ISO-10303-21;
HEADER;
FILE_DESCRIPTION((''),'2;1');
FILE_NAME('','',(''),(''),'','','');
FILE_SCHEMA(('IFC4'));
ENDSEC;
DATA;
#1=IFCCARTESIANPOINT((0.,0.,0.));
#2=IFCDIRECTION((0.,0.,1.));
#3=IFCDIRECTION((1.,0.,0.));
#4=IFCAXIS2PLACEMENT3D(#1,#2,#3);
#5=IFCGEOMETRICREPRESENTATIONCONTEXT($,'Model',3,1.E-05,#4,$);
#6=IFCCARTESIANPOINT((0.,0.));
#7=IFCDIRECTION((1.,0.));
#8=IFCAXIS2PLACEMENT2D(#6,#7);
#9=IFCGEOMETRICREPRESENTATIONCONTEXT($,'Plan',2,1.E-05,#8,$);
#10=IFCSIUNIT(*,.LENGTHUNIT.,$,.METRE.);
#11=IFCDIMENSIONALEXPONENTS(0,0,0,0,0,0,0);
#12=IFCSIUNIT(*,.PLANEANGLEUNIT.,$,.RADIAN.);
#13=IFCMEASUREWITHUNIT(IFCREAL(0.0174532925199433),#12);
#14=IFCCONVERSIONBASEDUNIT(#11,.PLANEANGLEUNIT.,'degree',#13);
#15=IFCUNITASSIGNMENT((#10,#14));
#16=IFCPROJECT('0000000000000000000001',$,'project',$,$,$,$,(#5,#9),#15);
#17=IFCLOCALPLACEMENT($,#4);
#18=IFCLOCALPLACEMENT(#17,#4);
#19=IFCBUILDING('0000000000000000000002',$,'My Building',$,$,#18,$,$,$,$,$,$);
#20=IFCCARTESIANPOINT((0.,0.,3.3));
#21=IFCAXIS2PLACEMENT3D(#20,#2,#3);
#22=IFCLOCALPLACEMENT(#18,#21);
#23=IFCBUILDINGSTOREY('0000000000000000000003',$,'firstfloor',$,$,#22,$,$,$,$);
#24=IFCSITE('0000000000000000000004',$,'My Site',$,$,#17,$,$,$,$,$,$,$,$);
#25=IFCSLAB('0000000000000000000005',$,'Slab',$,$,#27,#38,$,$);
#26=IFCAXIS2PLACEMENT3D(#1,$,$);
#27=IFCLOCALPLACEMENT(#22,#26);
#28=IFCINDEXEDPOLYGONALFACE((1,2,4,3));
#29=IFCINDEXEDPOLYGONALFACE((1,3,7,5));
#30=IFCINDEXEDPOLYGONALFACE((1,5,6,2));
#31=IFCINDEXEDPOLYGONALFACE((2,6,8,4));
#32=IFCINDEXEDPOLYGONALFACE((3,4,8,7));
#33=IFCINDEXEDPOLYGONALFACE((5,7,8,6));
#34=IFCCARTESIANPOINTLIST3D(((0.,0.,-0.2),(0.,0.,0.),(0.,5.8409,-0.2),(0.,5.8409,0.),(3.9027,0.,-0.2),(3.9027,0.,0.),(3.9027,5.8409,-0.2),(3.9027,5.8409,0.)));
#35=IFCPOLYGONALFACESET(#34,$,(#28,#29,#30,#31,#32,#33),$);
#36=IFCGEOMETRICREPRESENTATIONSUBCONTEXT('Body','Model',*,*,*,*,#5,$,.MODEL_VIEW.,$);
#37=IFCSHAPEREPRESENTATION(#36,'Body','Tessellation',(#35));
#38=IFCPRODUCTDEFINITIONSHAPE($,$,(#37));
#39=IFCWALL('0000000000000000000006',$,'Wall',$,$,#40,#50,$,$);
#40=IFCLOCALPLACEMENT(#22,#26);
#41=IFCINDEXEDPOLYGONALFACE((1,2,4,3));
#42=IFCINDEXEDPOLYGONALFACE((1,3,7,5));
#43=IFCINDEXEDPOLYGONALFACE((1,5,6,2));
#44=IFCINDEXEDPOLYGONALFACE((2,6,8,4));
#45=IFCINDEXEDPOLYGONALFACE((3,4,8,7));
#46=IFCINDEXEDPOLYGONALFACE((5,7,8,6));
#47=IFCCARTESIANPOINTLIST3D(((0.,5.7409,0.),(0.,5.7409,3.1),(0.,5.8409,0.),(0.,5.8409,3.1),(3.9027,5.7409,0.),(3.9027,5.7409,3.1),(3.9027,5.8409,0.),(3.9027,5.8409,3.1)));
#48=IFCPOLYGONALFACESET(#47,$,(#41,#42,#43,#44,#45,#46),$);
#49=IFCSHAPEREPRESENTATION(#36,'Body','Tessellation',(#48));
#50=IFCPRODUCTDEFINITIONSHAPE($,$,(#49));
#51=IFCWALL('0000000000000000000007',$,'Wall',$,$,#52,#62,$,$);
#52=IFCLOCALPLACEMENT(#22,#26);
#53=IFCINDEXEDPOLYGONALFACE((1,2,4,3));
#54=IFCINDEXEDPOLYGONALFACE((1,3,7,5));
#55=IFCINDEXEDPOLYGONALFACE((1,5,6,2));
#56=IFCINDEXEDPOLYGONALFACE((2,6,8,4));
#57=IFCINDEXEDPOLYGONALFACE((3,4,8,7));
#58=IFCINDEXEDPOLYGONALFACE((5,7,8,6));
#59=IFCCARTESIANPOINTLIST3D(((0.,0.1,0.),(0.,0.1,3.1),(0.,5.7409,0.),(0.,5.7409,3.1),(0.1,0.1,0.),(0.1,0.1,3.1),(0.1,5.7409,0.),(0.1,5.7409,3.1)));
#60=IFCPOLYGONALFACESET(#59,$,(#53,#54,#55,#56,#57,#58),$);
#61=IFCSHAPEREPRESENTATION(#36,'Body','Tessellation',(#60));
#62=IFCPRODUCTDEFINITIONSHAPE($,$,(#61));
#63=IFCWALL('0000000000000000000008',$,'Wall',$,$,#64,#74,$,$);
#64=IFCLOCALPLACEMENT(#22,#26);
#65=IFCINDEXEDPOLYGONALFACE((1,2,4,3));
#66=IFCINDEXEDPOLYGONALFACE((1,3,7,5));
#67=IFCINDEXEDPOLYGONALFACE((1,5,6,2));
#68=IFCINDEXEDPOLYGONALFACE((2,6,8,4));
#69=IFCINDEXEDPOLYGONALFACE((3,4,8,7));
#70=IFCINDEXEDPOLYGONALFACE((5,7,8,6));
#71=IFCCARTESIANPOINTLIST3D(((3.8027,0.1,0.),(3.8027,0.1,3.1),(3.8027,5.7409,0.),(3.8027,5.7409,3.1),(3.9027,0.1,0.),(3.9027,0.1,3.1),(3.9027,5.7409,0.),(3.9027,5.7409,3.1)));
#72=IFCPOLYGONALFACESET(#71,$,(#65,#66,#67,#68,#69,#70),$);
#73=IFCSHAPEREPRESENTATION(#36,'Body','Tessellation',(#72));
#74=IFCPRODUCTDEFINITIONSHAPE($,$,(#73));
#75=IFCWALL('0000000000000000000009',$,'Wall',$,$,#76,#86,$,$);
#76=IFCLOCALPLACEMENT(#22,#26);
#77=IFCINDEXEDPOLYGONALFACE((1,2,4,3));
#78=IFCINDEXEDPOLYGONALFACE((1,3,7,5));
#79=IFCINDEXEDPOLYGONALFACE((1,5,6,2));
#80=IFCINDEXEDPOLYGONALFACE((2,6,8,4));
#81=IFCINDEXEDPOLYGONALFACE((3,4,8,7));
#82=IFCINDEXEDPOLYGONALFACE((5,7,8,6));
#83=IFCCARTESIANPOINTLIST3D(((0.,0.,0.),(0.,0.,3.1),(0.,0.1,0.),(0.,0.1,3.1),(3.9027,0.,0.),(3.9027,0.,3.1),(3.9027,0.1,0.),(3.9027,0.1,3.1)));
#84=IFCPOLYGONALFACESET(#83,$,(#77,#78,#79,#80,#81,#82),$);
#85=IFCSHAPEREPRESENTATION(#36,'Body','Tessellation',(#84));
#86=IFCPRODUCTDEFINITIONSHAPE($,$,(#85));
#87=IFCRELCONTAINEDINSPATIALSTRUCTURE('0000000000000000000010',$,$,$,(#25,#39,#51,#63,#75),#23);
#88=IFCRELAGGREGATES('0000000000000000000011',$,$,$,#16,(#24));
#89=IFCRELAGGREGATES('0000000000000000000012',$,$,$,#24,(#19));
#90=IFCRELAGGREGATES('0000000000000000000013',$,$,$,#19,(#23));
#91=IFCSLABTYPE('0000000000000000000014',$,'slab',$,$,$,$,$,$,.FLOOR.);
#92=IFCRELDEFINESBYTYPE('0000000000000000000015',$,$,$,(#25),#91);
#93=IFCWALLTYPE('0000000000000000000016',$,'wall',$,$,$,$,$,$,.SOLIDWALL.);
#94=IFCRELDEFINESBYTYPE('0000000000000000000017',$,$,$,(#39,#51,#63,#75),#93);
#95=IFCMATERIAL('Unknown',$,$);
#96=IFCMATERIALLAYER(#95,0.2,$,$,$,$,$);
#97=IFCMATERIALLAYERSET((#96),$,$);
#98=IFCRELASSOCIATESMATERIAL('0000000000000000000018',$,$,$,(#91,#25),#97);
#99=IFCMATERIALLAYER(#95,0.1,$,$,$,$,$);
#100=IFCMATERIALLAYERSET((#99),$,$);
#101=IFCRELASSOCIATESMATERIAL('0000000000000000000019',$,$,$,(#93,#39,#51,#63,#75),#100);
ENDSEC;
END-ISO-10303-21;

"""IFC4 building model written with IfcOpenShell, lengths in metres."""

from ifc_helpers import new_model, entity, si_unit, converted_unit, frame, origin_with_axes, origin_2d_with_axis, place, context, subcontext, project, spatial, line, indexed_curve, outline, extrude, clip, halfspace, material, layer, layer_set, layer_usage, type_object, element, save


model = new_model("IFC4")

# Units and contexts
model_context = context("Model", 3, precision=1e-05, world=origin_with_axes())
plan_context = context("Plan", 2, precision=1e-05, world=origin_2d_with_axis())
body_context = subcontext(model_context, "Body", "Model", "MODEL_VIEW")
ifc_project = project(units=[si_unit("LENGTHUNIT", "METRE"), converted_unit("PLANEANGLEUNIT", "degree", entity("IfcReal", 0.0174532925199433), si_unit("PLANEANGLEUNIT", "RADIAN"), dimensions=[0, 0, 0, 0, 0, 0, 0])], contexts=[model_context, plan_context])

# Site, building, storey
site_placement = place(None, origin_with_axes())
site = spatial("IfcSite", under=ifc_project, at=site_placement, Name="My Site")
building_placement = place(site_placement, origin_with_axes())
building = spatial("IfcBuilding", under=site, at=building_placement, Name="My Building")
storey_placement = place(building_placement, frame((0.0, 0.0, 3.3), z_axis=(0.0, 0.0, 1.0), x_axis=(1.0, 0.0, 0.0)))
storey = spatial("IfcBuildingStorey", under=building, at=storey_placement, Name="firstfloor")

# Slab
ifc_material = material(Name="Unknown")
ifc_layer_1 = layer(ifc_material, 0.2)
ifc_layer_set_1 = layer_set([ifc_layer_1])
ifc_layer_usage_1 = layer_usage(ifc_layer_set_1, "AXIS3", "POSITIVE", 0.0)
slab_type = type_object("IfcSlabType", Name="slab", PredefinedType="FLOOR", material=ifc_layer_set_1)
slab_placement = place(storey_placement, frame((0.0, 0.0, -0.2), z_axis=(0.0, 0.0, 1.0), x_axis=(1.0, 0.0, 0.0)))
element("IfcSlab", 1, at=slab_placement, inside=storey, type_object=slab_type, material=ifc_layer_usage_1, Name="Slab", context=body_context, shape_type="SweptSolid", body=[
    extrude(outline(indexed_curve([(0.0, 0.0), (3.9027, 0.0), (3.9027, 5.8409), (0.0, 5.8409)], segments=[line(3, 2), line(2, 1), line(1, 4), line(4, 3)], self_intersect=False)), None, (0.0, 0.0, 1.0), 0.2),
])

# Walls
ifc_layer_2 = layer(ifc_material, 0.1)
ifc_layer_set_2 = layer_set([ifc_layer_2])
ifc_layer_usage_2 = layer_usage(ifc_layer_set_2, "AXIS2", "POSITIVE", 0.0)
wall_type = type_object("IfcWallType", Name="wall", PredefinedType="SOLIDWALL", material=ifc_layer_set_2)
wall_1_placement = place(storey_placement, frame((0.0, 5.7409, 0.0), z_axis=(0.0, 0.0, 1.0), x_axis=(1.0, 0.0, 0.0)))
element("IfcWall", 2, at=wall_1_placement, inside=storey, type_object=wall_type, material=ifc_layer_usage_2, Name="Wall", context=body_context, shape_type="Clipping", body=[
    clip(extrude(outline(indexed_curve([(0.0, 0.0), (0.0, 0.1), (3.9027, 0.1), (3.9027, 0.0), (0.0, 0.0)], self_intersect=False)), origin_with_axes(), (0.0, 0.0, 1.0), 6.4), halfspace(frame((0.0, 0.0, 3.1), z_axis=(0.0, 0.0, 1.0), x_axis=(-1.0, 0.0, 0.0)), False)),
])
ifc_layer_usage_3 = layer_usage(ifc_layer_set_2, "AXIS2", "POSITIVE", 0.0)
wall_2_placement = place(storey_placement, frame((0.0, 5.7409, 0.0), z_axis=(0.0, 0.0, 1.0), x_axis=(0.0, -1.0, 0.0)))
element("IfcWall", 3, at=wall_2_placement, inside=storey, type_object=wall_type, material=ifc_layer_usage_3, Name="Wall", context=body_context, shape_type="Clipping", body=[
    clip(extrude(outline(indexed_curve([(0.0, 0.0), (0.0, 0.1), (5.6409, 0.1), (5.6409, 0.0), (0.0, 0.0)], self_intersect=False)), origin_with_axes(), (0.0, 0.0, 1.0), 6.4), halfspace(frame((0.0, 0.0, 3.1), z_axis=(0.0, 0.0, 1.0), x_axis=(-1.0, 0.0, 0.0)), False)),
])
ifc_layer_usage_4 = layer_usage(ifc_layer_set_2, "AXIS2", "POSITIVE", 0.0)
wall_3_placement = place(storey_placement, frame((3.8027, 5.7409, 0.0), z_axis=(0.0, 0.0, 1.0), x_axis=(0.0, -1.0, 0.0)))
element("IfcWall", 4, at=wall_3_placement, inside=storey, type_object=wall_type, material=ifc_layer_usage_4, Name="Wall", context=body_context, shape_type="Clipping", body=[
    clip(extrude(outline(indexed_curve([(0.0, 0.0), (0.0, 0.1), (5.6409, 0.1), (5.6409, 0.0), (0.0, 0.0)], self_intersect=False)), origin_with_axes(), (0.0, 0.0, 1.0), 6.4), halfspace(frame((0.0, 0.0, 3.1), z_axis=(0.0, 0.0, 1.0), x_axis=(-1.0, 0.0, 0.0)), False)),
])
ifc_layer_usage_5 = layer_usage(ifc_layer_set_2, "AXIS2", "POSITIVE", 0.0)
wall_4_placement = place(storey_placement, origin_with_axes())
element("IfcWall", 5, at=wall_4_placement, inside=storey, type_object=wall_type, material=ifc_layer_usage_5, Name="Wall", context=body_context, shape_type="Clipping", body=[
    clip(extrude(outline(indexed_curve([(0.0, 0.0), (0.0, 0.1), (3.9027, 0.1), (3.9027, 0.0), (0.0, 0.0)], self_intersect=False)), origin_with_axes(), (0.0, 0.0, 1.0), 6.4), halfspace(frame((0.0, 0.0, 3.1), z_axis=(0.0, 0.0, 1.0), x_axis=(-1.0, 0.0, 0.0)), False)),
])

save(model, "model.ifc")
